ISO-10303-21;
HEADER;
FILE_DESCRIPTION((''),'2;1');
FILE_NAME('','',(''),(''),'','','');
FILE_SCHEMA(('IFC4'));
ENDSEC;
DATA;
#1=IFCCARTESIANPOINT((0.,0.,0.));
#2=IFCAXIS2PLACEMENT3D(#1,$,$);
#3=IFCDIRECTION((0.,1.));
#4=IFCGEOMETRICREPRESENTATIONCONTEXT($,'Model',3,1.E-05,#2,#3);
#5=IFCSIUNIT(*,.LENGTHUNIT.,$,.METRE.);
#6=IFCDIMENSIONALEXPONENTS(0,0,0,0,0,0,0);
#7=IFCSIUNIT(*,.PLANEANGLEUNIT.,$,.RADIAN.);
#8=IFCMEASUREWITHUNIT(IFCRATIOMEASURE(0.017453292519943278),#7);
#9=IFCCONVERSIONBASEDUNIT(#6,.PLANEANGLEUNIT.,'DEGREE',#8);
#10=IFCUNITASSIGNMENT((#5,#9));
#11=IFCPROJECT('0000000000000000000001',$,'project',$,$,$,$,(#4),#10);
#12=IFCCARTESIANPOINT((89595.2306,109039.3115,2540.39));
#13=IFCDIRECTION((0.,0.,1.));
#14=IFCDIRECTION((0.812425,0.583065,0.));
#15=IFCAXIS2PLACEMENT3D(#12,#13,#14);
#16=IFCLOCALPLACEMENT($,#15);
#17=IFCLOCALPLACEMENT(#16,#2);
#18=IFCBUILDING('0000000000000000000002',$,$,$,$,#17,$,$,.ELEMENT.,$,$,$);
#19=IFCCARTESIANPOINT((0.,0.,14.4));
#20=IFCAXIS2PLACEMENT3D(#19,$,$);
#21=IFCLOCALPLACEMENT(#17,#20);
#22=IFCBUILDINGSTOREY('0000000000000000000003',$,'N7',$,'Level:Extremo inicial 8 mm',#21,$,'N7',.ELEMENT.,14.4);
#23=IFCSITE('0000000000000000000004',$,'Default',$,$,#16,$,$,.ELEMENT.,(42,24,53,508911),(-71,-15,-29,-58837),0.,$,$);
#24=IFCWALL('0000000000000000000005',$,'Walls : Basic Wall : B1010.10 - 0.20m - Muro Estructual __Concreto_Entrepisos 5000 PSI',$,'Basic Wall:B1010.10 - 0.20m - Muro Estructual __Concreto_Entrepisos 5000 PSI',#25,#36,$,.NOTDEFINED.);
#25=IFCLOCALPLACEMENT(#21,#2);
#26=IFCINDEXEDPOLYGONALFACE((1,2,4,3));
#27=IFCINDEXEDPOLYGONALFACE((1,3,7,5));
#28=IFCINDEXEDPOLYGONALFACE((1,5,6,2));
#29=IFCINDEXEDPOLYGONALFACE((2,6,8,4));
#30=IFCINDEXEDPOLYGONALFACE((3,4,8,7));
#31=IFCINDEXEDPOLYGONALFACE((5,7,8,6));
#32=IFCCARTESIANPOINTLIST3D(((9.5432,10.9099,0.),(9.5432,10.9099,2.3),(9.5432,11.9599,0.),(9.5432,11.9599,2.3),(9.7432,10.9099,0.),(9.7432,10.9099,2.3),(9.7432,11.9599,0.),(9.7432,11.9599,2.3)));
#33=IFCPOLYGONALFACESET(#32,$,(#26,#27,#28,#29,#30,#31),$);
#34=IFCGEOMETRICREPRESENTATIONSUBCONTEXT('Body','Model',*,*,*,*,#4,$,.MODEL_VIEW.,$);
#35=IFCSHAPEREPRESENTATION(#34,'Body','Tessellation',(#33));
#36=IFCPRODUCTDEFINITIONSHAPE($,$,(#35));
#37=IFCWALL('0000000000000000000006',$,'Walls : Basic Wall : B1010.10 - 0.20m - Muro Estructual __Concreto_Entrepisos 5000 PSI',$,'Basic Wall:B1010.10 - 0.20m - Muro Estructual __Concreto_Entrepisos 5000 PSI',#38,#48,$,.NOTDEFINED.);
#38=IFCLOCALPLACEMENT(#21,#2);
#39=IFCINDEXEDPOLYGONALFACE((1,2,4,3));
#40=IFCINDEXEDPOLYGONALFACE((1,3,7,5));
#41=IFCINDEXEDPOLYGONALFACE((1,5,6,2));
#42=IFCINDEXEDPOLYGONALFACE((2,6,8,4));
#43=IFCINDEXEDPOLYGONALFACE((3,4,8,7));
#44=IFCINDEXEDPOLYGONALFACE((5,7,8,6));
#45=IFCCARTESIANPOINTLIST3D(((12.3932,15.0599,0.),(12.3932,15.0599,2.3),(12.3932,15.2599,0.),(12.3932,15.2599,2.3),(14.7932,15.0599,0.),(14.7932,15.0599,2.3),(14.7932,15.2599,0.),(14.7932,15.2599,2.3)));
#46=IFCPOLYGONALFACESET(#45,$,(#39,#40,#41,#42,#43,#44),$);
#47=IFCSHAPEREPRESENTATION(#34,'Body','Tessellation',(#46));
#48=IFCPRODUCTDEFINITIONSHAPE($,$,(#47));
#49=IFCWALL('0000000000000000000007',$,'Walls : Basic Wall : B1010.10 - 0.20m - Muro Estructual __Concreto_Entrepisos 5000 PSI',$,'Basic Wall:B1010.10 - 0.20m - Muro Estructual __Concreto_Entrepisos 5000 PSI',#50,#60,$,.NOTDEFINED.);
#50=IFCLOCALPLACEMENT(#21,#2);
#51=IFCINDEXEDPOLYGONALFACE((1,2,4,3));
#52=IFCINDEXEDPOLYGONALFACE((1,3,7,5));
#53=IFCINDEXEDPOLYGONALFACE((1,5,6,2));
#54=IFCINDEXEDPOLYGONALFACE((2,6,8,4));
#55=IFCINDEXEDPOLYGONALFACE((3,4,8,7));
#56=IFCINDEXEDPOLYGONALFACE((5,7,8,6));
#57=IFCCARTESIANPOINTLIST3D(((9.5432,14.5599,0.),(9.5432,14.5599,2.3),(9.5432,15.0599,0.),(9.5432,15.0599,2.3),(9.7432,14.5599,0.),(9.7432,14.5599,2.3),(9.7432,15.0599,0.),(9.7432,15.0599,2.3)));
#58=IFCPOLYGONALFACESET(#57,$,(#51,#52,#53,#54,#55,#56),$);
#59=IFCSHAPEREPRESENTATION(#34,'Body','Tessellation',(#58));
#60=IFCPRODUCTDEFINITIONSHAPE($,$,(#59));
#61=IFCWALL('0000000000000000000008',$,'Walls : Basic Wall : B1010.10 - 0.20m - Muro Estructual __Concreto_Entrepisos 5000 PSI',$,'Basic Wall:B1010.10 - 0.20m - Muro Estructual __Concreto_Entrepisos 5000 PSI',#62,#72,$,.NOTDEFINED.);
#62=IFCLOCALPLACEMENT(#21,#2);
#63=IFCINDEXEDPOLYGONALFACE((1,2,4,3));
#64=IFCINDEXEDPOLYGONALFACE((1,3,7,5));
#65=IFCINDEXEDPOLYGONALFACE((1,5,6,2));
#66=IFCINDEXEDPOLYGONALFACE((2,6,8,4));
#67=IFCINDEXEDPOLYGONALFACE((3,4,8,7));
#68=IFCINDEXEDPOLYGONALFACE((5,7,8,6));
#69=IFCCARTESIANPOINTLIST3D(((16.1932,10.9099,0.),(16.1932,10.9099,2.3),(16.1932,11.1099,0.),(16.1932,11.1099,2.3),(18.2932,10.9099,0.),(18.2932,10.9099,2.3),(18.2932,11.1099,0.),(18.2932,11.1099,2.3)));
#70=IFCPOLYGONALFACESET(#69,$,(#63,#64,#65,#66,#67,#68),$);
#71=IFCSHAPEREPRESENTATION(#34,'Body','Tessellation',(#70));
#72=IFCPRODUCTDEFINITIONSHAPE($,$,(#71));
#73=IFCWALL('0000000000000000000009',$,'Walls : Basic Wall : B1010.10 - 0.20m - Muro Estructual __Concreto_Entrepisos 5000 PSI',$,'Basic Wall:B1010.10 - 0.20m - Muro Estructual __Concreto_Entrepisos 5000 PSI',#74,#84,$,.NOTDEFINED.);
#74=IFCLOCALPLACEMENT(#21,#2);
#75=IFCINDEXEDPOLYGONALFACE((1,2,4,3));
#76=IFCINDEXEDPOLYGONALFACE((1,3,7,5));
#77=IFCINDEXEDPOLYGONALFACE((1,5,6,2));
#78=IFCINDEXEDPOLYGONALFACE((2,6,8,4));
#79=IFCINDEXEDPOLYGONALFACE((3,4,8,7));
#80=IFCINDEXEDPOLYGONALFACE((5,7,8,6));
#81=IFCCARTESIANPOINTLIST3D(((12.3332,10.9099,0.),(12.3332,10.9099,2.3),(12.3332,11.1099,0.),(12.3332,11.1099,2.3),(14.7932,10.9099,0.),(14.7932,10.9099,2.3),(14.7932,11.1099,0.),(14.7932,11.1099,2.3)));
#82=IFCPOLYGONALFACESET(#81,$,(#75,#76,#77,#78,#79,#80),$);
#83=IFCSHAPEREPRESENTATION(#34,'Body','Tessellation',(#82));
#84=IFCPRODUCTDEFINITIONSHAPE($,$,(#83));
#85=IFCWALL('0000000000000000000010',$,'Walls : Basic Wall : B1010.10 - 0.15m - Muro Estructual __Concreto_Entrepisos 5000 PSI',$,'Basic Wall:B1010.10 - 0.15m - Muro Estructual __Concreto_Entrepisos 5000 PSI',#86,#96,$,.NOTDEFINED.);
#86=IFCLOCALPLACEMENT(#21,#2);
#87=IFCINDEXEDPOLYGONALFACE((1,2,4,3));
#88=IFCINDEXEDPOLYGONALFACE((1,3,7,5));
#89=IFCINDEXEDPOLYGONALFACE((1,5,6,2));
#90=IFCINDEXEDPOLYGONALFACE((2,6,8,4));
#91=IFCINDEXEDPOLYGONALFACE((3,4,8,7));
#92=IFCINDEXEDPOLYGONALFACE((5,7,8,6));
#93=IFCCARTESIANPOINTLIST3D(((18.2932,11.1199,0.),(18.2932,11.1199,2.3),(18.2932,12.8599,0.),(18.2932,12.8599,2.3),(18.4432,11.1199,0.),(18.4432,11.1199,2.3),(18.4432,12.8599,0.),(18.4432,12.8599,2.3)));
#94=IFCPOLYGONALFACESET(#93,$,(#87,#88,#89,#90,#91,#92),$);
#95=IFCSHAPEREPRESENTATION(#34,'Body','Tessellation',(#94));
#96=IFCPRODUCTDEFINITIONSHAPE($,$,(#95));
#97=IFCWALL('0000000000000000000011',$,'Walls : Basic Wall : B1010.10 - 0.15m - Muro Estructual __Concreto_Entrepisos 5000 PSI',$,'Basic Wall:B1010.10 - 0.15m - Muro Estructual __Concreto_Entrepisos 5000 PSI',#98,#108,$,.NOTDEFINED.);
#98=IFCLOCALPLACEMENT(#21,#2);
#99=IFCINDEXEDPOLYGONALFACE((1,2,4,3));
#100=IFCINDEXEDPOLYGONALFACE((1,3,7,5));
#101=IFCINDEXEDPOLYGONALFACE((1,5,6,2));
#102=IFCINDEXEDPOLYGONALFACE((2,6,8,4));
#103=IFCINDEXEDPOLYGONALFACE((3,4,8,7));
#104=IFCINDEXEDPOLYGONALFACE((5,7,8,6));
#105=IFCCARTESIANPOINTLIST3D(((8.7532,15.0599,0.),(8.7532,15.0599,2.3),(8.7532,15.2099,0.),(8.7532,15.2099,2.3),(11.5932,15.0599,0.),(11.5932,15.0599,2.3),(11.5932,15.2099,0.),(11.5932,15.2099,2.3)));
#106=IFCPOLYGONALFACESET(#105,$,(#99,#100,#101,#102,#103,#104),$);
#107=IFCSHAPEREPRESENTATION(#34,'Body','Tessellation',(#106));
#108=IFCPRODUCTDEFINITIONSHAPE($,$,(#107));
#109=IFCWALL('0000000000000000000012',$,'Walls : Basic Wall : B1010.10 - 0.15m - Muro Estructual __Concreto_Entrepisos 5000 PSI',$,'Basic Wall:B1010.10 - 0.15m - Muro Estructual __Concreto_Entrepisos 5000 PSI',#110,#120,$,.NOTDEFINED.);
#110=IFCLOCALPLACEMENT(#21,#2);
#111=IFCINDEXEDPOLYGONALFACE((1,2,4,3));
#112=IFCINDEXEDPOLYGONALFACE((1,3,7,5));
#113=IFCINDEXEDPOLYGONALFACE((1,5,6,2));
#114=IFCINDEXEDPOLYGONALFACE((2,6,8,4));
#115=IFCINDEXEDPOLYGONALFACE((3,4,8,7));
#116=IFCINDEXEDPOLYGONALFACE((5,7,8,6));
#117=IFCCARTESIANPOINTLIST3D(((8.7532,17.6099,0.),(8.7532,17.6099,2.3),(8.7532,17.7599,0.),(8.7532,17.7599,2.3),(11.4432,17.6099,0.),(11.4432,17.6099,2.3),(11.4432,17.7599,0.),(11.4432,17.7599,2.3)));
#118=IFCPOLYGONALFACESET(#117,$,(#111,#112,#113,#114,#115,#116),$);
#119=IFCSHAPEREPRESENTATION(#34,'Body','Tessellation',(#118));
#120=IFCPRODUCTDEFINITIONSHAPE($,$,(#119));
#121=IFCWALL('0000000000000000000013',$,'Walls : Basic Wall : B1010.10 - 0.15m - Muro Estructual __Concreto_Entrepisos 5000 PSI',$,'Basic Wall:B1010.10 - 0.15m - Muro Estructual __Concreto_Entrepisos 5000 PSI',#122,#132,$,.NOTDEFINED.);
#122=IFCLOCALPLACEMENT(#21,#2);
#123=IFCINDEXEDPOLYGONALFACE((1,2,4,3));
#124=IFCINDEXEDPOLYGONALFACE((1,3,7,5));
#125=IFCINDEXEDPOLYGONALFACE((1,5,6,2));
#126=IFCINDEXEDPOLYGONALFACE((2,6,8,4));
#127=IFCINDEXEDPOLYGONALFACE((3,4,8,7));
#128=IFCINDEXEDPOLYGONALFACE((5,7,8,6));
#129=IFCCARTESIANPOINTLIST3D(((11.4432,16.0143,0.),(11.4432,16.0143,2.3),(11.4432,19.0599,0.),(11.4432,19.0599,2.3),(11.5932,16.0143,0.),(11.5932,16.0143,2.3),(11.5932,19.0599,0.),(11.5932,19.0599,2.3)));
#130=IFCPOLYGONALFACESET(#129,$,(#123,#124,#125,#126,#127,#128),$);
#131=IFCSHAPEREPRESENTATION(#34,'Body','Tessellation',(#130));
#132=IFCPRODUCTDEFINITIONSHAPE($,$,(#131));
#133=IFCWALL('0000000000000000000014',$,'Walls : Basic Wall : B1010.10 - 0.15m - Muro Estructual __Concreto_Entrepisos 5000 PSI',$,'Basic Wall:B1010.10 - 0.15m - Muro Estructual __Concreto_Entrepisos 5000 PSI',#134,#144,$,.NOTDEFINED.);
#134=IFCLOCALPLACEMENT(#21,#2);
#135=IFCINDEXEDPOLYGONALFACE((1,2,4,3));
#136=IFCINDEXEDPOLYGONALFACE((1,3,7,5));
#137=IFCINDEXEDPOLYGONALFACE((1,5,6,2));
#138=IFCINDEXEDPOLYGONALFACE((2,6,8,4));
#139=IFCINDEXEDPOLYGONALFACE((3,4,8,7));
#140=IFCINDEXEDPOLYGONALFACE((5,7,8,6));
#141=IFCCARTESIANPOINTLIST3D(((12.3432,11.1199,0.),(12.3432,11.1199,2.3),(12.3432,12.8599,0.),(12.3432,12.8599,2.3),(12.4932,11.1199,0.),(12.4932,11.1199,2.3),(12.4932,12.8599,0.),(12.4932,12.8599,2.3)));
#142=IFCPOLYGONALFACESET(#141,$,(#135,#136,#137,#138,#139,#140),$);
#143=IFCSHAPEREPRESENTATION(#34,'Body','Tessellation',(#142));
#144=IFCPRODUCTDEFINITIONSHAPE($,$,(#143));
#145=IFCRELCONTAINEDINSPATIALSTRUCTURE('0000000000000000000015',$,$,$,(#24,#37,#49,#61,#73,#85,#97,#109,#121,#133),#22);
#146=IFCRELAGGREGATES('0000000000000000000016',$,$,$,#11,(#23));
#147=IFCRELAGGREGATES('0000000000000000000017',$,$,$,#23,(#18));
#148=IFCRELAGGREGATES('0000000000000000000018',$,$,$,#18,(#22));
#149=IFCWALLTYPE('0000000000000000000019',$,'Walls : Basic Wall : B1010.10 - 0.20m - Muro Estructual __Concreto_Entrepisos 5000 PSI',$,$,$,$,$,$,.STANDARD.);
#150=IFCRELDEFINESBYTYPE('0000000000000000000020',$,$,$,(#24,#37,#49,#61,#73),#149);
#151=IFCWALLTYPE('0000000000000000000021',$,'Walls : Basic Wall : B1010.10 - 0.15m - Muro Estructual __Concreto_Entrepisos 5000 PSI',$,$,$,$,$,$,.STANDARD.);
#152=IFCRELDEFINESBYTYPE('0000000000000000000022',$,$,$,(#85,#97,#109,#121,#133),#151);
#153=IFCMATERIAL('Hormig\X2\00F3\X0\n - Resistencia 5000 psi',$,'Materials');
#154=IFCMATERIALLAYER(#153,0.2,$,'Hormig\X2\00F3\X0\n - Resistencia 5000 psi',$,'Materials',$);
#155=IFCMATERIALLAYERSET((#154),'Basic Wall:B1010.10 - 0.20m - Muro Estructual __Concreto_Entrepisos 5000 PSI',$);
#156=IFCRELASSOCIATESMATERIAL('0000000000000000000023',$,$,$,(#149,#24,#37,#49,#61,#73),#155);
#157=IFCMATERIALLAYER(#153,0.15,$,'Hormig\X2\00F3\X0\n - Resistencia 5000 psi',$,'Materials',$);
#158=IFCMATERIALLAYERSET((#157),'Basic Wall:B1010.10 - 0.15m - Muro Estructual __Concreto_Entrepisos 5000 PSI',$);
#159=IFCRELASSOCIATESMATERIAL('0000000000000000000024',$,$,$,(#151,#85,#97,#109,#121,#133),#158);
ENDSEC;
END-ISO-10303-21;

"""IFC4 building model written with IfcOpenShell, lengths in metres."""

from ifc_helpers import new_model, entity, si_unit, converted_unit, direction, frame, frame_2d, origin, place, context, subcontext, project, spatial, rectangle, extrude, material, layer, layer_set, layer_usage, type_object, element, save


model = new_model("IFC4")

# Units and contexts
model_context = context("Model", 3, precision=1e-05, world=origin(), true_north=direction((0.0, 1.0)))
body_context = subcontext(model_context, "Body", "Model", "MODEL_VIEW")
ifc_project = project(units=[si_unit("LENGTHUNIT", "METRE"), converted_unit("PLANEANGLEUNIT", "DEGREE", entity("IfcRatioMeasure", 0.017453292519943278), si_unit("PLANEANGLEUNIT", "RADIAN"), dimensions=[0, 0, 0, 0, 0, 0, 0])], contexts=[model_context])

# Site, building, storey
site_placement = place(None, frame((89595.2306, 109039.3115, 2540.39), z_axis=(0.0, 0.0, 1.0), x_axis=(0.812425, 0.583065, 0.0)))
site = spatial("IfcSite", under=ifc_project, at=site_placement, Name="Default", CompositionType="ELEMENT", RefLatitude=(42, 24, 53, 508911), RefLongitude=(-71, -15, -29, -58837), RefElevation=0.0)
building_placement = place(site_placement, origin())
building = spatial("IfcBuilding", under=site, at=building_placement, CompositionType="ELEMENT")
storey_placement = place(building_placement, frame((0.0, 0.0, 14.4)))
storey = spatial("IfcBuildingStorey", under=building, at=storey_placement, Name="N7", ObjectType="Level:Extremo inicial 8 mm", LongName="N7", CompositionType="ELEMENT", Elevation=14.4)

# Walls
ifc_material = material(Name="Hormigón - Resistencia 5000 psi", Category="Materials")
ifc_layer_1 = layer(ifc_material, 0.2, Name="Hormigón - Resistencia 5000 psi", Category="Materials")
ifc_layer_set_1 = layer_set([ifc_layer_1], Name="Basic Wall:B1010.10 - 0.20m - Muro Estructual __Concreto_Entrepisos 5000 PSI")
ifc_layer_usage_1 = layer_usage(ifc_layer_set_1, "AXIS2", "POSITIVE", -0.1)
wall_type_1 = type_object("IfcWallType", Name="Walls : Basic Wall : B1010.10 - 0.20m - Muro Estructual __Concreto_Entrepisos 5000 PSI", PredefinedType="STANDARD", material=ifc_layer_set_1)
wall_1_placement = place(storey_placement, frame((9.6432, 11.9599, 0.0), z_axis=(0.0, 0.0, 1.0), x_axis=(0.0, -1.0, 0.0)))
element("IfcWall", 1, at=wall_1_placement, inside=storey, type_object=wall_type_1, material=ifc_layer_usage_1, Name="Walls : Basic Wall : B1010.10 - 0.20m - Muro Estructual __Concreto_Entrepisos 5000 PSI", ObjectType="Basic Wall:B1010.10 - 0.20m - Muro Estructual __Concreto_Entrepisos 5000 PSI", PredefinedType="NOTDEFINED", context=body_context, shape_type="SweptSolid", body=[
    extrude(rectangle(XDim=1.05, YDim=0.2, at=frame_2d((0.525, 0.0), x_axis=(-1.0, 0.0))), origin(), (0.0, 0.0, 1.0), 2.3),
])
ifc_layer_usage_2 = layer_usage(ifc_layer_set_1, "AXIS2", "POSITIVE", -0.1)
wall_2_placement = place(storey_placement, frame((12.3932, 15.1599, 0.0)))
element("IfcWall", 2, at=wall_2_placement, inside=storey, type_object=wall_type_1, material=ifc_layer_usage_2, Name="Walls : Basic Wall : B1010.10 - 0.20m - Muro Estructual __Concreto_Entrepisos 5000 PSI", ObjectType="Basic Wall:B1010.10 - 0.20m - Muro Estructual __Concreto_Entrepisos 5000 PSI", PredefinedType="NOTDEFINED", context=body_context, shape_type="SweptSolid", body=[
    extrude(rectangle(XDim=2.4, YDim=0.2, at=frame_2d((1.2, 0.0), x_axis=(-1.0, 0.0))), origin(), (0.0, 0.0, 1.0), 2.3),
])
ifc_layer_usage_3 = layer_usage(ifc_layer_set_1, "AXIS2", "POSITIVE", -0.1)
wall_3_placement = place(storey_placement, frame((9.6432, 14.5599, 0.0), z_axis=(0.0, 0.0, 1.0), x_axis=(0.0, 1.0, 0.0)))
element("IfcWall", 3, at=wall_3_placement, inside=storey, type_object=wall_type_1, material=ifc_layer_usage_3, Name="Walls : Basic Wall : B1010.10 - 0.20m - Muro Estructual __Concreto_Entrepisos 5000 PSI", ObjectType="Basic Wall:B1010.10 - 0.20m - Muro Estructual __Concreto_Entrepisos 5000 PSI", PredefinedType="NOTDEFINED", context=body_context, shape_type="SweptSolid", body=[
    extrude(rectangle(XDim=0.5, YDim=0.2, at=frame_2d((0.25, 0.0), x_axis=(-1.0, 0.0))), origin(), (0.0, 0.0, 1.0), 2.3),
])
ifc_layer_usage_4 = layer_usage(ifc_layer_set_1, "AXIS2", "NEGATIVE", 0.1)
wall_4_placement = place(storey_placement, frame((18.2932, 11.0099, 0.0), z_axis=(0.0, 0.0, 1.0), x_axis=(-1.0, 0.0, 0.0)))
element("IfcWall", 4, at=wall_4_placement, inside=storey, type_object=wall_type_1, material=ifc_layer_usage_4, Name="Walls : Basic Wall : B1010.10 - 0.20m - Muro Estructual __Concreto_Entrepisos 5000 PSI", ObjectType="Basic Wall:B1010.10 - 0.20m - Muro Estructual __Concreto_Entrepisos 5000 PSI", PredefinedType="NOTDEFINED", context=body_context, shape_type="SweptSolid", body=[
    extrude(rectangle(XDim=2.1, YDim=0.2, at=frame_2d((1.05, 0.0), x_axis=(-1.0, 0.0))), origin(), (0.0, 0.0, 1.0), 2.3),
])
ifc_layer_usage_5 = layer_usage(ifc_layer_set_1, "AXIS2", "POSITIVE", -0.1)
wall_5_placement = place(storey_placement, frame((12.3332, 11.0099, 0.0)))
element("IfcWall", 5, at=wall_5_placement, inside=storey, type_object=wall_type_1, material=ifc_layer_usage_5, Name="Walls : Basic Wall : B1010.10 - 0.20m - Muro Estructual __Concreto_Entrepisos 5000 PSI", ObjectType="Basic Wall:B1010.10 - 0.20m - Muro Estructual __Concreto_Entrepisos 5000 PSI", PredefinedType="NOTDEFINED", context=body_context, shape_type="SweptSolid", body=[
    extrude(rectangle(XDim=2.46, YDim=0.2, at=frame_2d((1.23, 0.0), x_axis=(-1.0, 0.0))), origin(), (0.0, 0.0, 1.0), 2.3),
])
ifc_layer_2 = layer(ifc_material, 0.15, Name="Hormigón - Resistencia 5000 psi", Category="Materials")
ifc_layer_set_2 = layer_set([ifc_layer_2], Name="Basic Wall:B1010.10 - 0.15m - Muro Estructual __Concreto_Entrepisos 5000 PSI")
ifc_layer_usage_6 = layer_usage(ifc_layer_set_2, "AXIS2", "NEGATIVE", 0.075)
wall_type_2 = type_object("IfcWallType", Name="Walls : Basic Wall : B1010.10 - 0.15m - Muro Estructual __Concreto_Entrepisos 5000 PSI", PredefinedType="STANDARD", material=ifc_layer_set_2)
wall_6_placement = place(storey_placement, frame((18.3682, 11.1199, 0.0), z_axis=(0.0, 0.0, 1.0), x_axis=(0.0, 1.0, 0.0)))
element("IfcWall", 6, at=wall_6_placement, inside=storey, type_object=wall_type_2, material=ifc_layer_usage_6, Name="Walls : Basic Wall : B1010.10 - 0.15m - Muro Estructual __Concreto_Entrepisos 5000 PSI", ObjectType="Basic Wall:B1010.10 - 0.15m - Muro Estructual __Concreto_Entrepisos 5000 PSI", PredefinedType="NOTDEFINED", context=body_context, shape_type="SweptSolid", body=[
    extrude(rectangle(XDim=1.74, YDim=0.15, at=frame_2d((0.87, 0.0), x_axis=(-1.0, 0.0))), origin(), (0.0, 0.0, 1.0), 2.3),
])
ifc_layer_usage_7 = layer_usage(ifc_layer_set_2, "AXIS2", "POSITIVE", -0.075)
wall_7_placement = place(storey_placement, frame((8.7532, 15.1349, 0.0)))
element("IfcWall", 7, at=wall_7_placement, inside=storey, type_object=wall_type_2, material=ifc_layer_usage_7, Name="Walls : Basic Wall : B1010.10 - 0.15m - Muro Estructual __Concreto_Entrepisos 5000 PSI", ObjectType="Basic Wall:B1010.10 - 0.15m - Muro Estructual __Concreto_Entrepisos 5000 PSI", PredefinedType="NOTDEFINED", context=body_context, shape_type="SweptSolid", body=[
    extrude(rectangle(XDim=2.84, YDim=0.15, at=frame_2d((1.42, 0.0), x_axis=(-1.0, 0.0))), origin(), (0.0, 0.0, 1.0), 2.3),
])
ifc_layer_usage_8 = layer_usage(ifc_layer_set_2, "AXIS2", "POSITIVE", -0.075)
wall_8_placement = place(storey_placement, frame((8.7532, 17.6849, 0.0)))
element("IfcWall", 8, at=wall_8_placement, inside=storey, type_object=wall_type_2, material=ifc_layer_usage_8, Name="Walls : Basic Wall : B1010.10 - 0.15m - Muro Estructual __Concreto_Entrepisos 5000 PSI", ObjectType="Basic Wall:B1010.10 - 0.15m - Muro Estructual __Concreto_Entrepisos 5000 PSI", PredefinedType="NOTDEFINED", context=body_context, shape_type="SweptSolid", body=[
    extrude(rectangle(XDim=2.69, YDim=0.15, at=frame_2d((1.345, 0.0), x_axis=(-1.0, 0.0))), origin(), (0.0, 0.0, 1.0), 2.3),
])
ifc_layer_usage_9 = layer_usage(ifc_layer_set_2, "AXIS2", "POSITIVE", -0.075)
wall_9_placement = place(storey_placement, frame((11.5182, 16.0143, 0.0), z_axis=(0.0, 0.0, 1.0), x_axis=(0.0, 1.0, 0.0)))
element("IfcWall", 9, at=wall_9_placement, inside=storey, type_object=wall_type_2, material=ifc_layer_usage_9, Name="Walls : Basic Wall : B1010.10 - 0.15m - Muro Estructual __Concreto_Entrepisos 5000 PSI", ObjectType="Basic Wall:B1010.10 - 0.15m - Muro Estructual __Concreto_Entrepisos 5000 PSI", PredefinedType="NOTDEFINED", context=body_context, shape_type="SweptSolid", body=[
    extrude(rectangle(XDim=3.0455, YDim=0.15, at=frame_2d((1.5228, 0.0), x_axis=(-1.0, 0.0))), origin(), (0.0, 0.0, 1.0), 2.3),
])
ifc_layer_usage_10 = layer_usage(ifc_layer_set_2, "AXIS2", "POSITIVE", -0.075)
wall_10_placement = place(storey_placement, frame((12.4182, 11.1199, 0.0), z_axis=(0.0, 0.0, 1.0), x_axis=(0.0, 1.0, 0.0)))
element("IfcWall", 10, at=wall_10_placement, inside=storey, type_object=wall_type_2, material=ifc_layer_usage_10, Name="Walls : Basic Wall : B1010.10 - 0.15m - Muro Estructual __Concreto_Entrepisos 5000 PSI", ObjectType="Basic Wall:B1010.10 - 0.15m - Muro Estructual __Concreto_Entrepisos 5000 PSI", PredefinedType="NOTDEFINED", context=body_context, shape_type="SweptSolid", body=[
    extrude(rectangle(XDim=1.74, YDim=0.15, at=frame_2d((0.87, 0.0), x_axis=(-1.0, 0.0))), origin(), (0.0, 0.0, 1.0), 2.3),
])

save(model, "model.ifc")
